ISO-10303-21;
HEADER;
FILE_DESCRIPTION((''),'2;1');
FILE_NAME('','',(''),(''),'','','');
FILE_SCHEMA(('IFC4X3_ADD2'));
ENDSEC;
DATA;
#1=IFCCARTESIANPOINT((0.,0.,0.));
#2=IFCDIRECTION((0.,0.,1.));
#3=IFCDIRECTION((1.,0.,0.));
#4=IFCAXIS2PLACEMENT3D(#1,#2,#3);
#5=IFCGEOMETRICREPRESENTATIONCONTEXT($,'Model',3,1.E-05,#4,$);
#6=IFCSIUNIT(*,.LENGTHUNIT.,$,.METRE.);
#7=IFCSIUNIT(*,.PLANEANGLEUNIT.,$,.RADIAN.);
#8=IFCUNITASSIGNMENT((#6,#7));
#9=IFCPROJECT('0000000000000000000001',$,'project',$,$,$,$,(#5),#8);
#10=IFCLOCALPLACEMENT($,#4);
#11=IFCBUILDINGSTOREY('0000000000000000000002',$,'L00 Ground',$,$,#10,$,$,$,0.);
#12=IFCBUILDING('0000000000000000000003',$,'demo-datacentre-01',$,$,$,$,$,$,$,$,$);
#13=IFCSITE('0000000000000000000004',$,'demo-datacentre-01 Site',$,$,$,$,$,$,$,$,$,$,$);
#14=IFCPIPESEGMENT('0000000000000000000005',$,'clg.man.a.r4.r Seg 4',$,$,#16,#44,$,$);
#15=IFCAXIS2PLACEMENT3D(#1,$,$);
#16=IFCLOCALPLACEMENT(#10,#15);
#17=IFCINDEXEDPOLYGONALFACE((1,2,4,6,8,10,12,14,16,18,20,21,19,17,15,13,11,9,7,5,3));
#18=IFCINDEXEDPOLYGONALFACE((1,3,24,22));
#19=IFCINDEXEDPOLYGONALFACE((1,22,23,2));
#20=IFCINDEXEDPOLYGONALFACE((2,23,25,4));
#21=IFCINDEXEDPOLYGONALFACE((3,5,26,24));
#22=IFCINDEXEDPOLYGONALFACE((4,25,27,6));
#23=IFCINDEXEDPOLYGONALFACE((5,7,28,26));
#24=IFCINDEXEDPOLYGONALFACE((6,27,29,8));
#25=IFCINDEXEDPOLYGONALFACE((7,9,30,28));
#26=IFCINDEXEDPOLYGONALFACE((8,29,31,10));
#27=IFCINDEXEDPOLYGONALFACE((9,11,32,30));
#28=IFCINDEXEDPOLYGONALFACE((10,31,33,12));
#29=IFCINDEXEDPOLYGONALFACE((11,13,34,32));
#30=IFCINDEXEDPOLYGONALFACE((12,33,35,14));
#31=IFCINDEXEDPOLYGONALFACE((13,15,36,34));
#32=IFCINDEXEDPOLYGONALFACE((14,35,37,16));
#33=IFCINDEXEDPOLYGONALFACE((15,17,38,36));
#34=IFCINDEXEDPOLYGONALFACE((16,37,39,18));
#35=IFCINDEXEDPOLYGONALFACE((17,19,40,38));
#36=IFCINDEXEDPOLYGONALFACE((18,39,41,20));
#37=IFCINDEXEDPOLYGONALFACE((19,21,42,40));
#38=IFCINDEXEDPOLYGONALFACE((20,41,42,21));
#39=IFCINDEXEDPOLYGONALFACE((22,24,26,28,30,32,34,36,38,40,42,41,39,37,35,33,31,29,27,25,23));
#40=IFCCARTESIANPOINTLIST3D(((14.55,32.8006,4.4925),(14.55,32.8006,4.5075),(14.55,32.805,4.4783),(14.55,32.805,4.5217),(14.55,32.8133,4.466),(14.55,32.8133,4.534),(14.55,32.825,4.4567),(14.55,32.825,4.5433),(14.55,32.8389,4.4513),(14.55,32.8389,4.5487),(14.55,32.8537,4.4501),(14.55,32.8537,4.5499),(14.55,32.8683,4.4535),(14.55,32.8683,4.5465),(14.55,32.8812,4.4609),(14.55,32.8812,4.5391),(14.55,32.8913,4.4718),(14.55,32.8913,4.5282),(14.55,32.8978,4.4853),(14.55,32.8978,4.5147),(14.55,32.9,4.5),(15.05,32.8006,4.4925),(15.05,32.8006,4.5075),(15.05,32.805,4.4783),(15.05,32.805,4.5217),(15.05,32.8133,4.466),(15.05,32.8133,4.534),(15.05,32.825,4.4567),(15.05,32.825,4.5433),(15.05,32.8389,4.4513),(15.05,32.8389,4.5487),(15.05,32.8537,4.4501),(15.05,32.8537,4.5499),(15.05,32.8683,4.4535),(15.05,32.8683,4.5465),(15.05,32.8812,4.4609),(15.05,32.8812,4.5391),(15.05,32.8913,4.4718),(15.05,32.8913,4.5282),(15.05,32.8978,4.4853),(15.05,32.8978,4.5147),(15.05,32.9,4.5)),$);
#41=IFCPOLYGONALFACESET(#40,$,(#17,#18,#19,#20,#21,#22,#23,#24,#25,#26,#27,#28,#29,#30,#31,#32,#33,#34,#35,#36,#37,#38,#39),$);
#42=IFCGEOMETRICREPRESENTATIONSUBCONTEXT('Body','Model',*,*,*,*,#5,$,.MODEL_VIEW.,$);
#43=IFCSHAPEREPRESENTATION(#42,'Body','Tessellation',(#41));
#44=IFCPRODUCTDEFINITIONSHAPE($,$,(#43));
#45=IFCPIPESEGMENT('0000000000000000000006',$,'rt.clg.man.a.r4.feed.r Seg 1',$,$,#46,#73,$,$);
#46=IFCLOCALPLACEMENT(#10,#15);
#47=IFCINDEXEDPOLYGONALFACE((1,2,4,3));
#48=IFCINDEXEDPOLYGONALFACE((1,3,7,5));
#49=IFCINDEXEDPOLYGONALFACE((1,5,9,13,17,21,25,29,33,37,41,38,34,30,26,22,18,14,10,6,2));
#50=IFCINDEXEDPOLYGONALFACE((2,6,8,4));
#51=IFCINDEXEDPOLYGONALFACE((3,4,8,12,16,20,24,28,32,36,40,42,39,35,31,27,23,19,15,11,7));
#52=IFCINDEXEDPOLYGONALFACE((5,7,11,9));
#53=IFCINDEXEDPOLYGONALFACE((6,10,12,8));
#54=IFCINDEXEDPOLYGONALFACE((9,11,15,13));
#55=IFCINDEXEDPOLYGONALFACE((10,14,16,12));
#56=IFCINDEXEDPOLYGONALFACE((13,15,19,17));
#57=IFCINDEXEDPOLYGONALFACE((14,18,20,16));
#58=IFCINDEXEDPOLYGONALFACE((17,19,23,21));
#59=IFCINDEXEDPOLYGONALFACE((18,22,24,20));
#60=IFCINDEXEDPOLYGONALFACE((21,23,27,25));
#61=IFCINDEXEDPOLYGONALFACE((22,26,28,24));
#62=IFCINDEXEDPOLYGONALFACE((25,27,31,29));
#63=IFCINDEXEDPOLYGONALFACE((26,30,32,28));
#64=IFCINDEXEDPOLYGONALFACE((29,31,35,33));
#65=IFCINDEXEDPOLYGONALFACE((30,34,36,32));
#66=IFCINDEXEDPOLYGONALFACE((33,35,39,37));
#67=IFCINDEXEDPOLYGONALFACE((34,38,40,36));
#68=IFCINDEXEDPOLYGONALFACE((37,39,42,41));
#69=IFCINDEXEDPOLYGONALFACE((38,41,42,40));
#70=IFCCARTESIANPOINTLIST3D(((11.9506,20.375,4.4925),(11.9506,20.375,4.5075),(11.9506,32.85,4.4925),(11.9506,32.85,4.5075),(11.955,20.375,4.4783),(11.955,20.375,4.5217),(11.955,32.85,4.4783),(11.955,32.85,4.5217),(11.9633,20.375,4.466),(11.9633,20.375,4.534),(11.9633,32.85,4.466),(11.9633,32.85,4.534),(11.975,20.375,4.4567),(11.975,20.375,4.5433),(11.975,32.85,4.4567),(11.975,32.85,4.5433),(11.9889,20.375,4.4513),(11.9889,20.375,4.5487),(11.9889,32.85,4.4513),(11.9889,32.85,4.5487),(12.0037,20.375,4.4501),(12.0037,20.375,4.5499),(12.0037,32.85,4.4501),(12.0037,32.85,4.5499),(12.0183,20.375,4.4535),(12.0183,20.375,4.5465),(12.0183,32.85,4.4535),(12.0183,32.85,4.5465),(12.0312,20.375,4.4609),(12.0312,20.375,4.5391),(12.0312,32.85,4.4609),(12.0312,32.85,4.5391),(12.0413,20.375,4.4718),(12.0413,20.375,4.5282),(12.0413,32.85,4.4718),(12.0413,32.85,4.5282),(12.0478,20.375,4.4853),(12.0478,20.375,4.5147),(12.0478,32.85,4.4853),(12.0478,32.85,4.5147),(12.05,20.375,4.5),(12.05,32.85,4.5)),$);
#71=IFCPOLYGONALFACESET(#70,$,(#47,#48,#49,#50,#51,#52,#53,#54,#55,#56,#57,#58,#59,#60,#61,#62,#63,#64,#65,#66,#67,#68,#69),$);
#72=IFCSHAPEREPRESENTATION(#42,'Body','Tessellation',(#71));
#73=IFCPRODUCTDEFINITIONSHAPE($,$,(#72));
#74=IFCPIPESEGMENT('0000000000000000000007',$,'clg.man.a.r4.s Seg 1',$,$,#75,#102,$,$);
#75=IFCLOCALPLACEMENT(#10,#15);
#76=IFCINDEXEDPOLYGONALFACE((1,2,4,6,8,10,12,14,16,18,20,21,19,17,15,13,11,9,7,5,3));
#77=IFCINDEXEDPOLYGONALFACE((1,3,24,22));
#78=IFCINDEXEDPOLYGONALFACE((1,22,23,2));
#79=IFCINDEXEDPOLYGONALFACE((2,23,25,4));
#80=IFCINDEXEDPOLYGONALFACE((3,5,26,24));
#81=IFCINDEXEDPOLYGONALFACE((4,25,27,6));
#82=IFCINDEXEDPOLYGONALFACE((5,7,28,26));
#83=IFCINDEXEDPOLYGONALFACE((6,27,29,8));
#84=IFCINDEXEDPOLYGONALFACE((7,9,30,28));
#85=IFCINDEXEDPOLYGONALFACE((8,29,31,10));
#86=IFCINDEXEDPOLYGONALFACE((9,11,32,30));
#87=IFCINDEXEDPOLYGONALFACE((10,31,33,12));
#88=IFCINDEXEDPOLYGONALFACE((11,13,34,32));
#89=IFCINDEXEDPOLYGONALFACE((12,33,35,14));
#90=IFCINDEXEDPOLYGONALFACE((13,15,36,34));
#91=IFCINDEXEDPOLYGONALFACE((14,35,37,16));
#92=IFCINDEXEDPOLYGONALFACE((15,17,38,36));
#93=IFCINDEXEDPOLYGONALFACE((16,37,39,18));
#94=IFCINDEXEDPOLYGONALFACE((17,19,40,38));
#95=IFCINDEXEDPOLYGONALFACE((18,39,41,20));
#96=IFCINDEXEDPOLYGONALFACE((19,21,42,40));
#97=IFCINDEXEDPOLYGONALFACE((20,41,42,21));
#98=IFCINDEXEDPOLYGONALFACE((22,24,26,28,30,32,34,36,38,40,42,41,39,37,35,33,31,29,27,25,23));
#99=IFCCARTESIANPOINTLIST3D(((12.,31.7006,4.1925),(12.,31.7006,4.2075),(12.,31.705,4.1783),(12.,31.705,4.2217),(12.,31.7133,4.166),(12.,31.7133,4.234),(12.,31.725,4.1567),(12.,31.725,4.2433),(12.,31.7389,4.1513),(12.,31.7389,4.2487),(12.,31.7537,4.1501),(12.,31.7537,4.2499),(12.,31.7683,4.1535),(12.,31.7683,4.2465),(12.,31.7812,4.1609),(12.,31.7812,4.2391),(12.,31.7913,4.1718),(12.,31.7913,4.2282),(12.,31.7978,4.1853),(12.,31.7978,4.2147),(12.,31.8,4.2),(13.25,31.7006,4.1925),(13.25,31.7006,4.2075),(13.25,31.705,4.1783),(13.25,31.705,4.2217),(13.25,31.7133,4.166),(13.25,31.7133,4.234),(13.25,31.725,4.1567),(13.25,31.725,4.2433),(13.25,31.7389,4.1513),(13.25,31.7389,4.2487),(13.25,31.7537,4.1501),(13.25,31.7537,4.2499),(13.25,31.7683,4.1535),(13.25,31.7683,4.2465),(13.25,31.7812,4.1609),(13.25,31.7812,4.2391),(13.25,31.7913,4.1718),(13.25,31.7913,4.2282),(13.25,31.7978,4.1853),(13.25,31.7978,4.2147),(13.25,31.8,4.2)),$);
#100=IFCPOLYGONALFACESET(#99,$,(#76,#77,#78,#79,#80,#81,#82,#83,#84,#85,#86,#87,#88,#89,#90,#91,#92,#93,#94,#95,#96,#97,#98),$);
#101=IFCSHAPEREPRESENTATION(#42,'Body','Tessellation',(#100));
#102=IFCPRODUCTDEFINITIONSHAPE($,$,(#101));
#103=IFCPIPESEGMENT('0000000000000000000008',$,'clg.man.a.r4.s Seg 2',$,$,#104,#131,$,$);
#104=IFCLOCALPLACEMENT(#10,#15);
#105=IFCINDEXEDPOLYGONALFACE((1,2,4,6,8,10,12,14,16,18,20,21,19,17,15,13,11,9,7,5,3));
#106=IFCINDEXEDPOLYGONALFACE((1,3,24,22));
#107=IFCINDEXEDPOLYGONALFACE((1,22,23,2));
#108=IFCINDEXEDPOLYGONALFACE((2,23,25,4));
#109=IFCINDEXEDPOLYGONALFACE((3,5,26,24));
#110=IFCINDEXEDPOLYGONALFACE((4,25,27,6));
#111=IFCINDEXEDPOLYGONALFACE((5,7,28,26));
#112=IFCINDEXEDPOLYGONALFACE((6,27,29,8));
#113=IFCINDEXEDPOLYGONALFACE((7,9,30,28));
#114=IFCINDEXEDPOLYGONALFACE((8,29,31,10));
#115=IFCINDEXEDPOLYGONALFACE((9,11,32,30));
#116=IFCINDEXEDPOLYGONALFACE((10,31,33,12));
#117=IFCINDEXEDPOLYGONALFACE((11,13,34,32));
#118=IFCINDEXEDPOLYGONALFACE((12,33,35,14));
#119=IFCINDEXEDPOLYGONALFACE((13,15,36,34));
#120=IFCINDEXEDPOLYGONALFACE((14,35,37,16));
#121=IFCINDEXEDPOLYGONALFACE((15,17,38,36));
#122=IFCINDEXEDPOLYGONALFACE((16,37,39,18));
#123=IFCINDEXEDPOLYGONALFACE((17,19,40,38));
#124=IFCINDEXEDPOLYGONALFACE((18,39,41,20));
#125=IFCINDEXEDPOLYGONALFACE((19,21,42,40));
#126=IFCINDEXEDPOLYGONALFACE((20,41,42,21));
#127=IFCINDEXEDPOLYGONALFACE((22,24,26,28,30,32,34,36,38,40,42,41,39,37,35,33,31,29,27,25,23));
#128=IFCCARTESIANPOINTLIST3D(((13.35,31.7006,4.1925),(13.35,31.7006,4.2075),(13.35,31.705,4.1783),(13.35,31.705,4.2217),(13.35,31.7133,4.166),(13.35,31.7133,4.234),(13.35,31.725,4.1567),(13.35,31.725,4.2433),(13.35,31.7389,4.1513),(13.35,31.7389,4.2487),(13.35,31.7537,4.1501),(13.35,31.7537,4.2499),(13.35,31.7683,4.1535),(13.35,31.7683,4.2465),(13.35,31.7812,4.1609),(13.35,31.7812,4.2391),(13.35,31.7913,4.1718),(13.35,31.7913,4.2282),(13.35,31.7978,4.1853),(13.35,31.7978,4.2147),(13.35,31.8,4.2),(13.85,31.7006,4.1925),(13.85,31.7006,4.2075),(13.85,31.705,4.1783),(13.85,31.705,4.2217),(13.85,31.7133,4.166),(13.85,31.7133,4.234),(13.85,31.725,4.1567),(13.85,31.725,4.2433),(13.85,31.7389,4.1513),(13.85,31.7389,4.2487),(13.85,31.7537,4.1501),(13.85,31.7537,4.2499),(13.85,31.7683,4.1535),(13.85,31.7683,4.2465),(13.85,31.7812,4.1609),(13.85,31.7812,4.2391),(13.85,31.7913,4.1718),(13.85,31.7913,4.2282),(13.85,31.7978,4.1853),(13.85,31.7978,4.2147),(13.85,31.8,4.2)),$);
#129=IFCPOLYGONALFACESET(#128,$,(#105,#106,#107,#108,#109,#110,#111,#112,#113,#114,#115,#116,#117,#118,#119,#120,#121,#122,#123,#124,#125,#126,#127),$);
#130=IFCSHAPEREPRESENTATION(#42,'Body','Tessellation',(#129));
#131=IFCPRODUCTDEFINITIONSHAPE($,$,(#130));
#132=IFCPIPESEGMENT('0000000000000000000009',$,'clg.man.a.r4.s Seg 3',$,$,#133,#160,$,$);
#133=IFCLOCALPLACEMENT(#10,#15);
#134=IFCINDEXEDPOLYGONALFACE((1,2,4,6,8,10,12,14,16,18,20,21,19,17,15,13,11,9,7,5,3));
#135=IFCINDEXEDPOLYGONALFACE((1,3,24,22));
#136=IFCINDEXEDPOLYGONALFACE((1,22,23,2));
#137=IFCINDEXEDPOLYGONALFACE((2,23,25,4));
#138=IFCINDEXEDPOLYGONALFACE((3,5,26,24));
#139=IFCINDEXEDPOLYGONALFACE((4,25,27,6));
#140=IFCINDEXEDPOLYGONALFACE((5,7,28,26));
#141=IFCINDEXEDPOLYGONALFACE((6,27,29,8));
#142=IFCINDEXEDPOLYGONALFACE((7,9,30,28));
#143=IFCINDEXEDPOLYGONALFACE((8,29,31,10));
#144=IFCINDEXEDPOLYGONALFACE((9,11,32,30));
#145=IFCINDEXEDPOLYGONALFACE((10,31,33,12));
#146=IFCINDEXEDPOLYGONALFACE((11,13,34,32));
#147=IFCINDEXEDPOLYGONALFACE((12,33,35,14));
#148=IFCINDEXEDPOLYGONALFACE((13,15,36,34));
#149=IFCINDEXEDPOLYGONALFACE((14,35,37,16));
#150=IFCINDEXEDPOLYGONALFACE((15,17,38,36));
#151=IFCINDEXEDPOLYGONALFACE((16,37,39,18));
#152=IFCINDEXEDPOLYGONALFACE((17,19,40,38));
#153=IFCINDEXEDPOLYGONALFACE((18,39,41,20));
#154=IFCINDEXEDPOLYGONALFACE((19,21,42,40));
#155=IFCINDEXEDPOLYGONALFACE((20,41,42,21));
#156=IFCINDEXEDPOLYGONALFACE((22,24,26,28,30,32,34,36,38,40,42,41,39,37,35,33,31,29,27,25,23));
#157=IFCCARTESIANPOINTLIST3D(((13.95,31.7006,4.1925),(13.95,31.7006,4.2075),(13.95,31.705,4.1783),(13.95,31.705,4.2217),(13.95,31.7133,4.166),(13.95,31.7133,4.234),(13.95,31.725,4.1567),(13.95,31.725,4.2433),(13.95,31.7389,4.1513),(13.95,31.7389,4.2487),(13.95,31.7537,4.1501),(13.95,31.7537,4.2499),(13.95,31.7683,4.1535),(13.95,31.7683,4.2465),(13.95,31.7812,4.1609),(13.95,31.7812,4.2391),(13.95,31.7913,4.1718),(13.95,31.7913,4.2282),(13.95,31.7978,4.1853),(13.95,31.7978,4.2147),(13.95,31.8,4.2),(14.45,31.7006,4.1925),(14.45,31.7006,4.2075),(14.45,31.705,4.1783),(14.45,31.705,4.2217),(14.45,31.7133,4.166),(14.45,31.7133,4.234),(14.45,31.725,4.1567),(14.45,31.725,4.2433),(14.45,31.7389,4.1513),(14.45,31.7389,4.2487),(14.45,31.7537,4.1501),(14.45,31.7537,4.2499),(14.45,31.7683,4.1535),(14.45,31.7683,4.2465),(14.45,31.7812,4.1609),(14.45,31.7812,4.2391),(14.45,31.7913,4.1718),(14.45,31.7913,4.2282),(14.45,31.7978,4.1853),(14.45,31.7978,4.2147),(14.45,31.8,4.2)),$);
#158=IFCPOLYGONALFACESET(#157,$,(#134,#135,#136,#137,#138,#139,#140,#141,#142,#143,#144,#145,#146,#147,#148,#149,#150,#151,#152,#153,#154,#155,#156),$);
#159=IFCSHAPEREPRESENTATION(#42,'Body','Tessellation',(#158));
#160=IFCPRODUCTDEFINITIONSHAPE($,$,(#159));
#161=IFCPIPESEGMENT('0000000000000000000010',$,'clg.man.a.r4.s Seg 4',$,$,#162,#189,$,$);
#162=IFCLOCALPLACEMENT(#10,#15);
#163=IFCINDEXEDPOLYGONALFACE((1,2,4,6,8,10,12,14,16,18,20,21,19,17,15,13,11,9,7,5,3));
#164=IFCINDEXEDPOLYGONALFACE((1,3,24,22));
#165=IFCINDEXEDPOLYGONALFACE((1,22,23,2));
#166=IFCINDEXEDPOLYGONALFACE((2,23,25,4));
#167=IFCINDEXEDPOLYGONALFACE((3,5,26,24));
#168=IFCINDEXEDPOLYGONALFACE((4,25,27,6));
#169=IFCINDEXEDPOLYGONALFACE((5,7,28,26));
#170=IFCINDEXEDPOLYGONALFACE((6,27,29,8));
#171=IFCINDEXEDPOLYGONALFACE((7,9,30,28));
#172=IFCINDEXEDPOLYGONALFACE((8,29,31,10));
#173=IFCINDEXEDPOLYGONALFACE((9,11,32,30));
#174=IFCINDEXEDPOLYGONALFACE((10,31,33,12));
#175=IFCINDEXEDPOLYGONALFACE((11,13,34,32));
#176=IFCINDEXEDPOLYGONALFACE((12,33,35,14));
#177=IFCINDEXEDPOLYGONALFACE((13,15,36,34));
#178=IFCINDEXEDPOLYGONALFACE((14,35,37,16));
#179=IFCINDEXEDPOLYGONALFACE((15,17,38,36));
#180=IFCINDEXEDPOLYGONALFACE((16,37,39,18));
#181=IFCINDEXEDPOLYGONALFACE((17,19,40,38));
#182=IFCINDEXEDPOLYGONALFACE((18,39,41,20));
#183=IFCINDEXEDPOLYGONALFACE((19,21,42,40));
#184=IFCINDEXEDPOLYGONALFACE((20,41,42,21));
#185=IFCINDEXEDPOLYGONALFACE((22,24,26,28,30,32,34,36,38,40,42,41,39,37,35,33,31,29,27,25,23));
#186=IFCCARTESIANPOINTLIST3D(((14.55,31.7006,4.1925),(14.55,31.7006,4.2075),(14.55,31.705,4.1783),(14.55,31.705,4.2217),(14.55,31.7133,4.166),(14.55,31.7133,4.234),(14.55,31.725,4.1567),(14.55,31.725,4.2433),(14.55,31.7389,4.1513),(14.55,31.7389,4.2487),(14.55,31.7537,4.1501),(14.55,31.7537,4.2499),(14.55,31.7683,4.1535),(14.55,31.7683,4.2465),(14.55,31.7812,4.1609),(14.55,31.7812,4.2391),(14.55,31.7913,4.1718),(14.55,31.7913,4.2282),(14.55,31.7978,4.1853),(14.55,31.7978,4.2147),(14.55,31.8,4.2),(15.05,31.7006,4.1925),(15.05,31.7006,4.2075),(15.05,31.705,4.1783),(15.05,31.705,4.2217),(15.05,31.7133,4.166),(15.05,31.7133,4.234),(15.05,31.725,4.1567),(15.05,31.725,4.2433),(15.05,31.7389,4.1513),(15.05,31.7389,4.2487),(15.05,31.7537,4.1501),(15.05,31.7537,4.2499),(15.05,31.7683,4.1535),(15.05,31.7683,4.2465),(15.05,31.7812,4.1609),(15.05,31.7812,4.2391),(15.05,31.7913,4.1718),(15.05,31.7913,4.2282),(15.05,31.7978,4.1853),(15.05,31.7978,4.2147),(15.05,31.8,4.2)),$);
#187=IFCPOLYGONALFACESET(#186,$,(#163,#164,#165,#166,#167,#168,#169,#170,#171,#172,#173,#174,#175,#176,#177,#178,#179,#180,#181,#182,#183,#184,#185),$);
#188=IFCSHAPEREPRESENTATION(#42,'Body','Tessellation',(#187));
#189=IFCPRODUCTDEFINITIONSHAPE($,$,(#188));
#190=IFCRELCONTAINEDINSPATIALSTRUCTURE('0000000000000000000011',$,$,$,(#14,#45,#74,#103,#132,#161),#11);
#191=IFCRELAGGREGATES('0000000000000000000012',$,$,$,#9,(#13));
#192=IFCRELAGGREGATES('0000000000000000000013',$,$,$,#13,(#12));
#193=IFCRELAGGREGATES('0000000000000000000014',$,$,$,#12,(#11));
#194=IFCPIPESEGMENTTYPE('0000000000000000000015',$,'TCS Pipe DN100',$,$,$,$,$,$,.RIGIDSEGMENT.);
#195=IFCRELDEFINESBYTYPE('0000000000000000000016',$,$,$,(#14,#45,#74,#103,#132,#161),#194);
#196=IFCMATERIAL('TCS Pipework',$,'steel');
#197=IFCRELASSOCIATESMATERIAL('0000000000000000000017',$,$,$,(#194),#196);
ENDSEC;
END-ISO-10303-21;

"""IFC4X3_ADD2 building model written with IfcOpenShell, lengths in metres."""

from ifc_helpers import new_model, si_unit, frame, origin_with_axes, place, context, subcontext, project, spatial, circle, extrude, material, type_object, element, save


model = new_model("IFC4X3_ADD2")

# Units and contexts
model_context = context("Model", 3, precision=1e-05, world=origin_with_axes())
body_context = subcontext(model_context, "Body", "Model", "MODEL_VIEW")
ifc_project = project(units=[si_unit("LENGTHUNIT", "METRE"), si_unit("PLANEANGLEUNIT", "RADIAN")], contexts=[model_context])

# Site, building, storey
site = spatial("IfcSite", under=ifc_project, Name="demo-datacentre-01 Site")
building = spatial("IfcBuilding", under=site, Name="demo-datacentre-01")
storey_placement = place(None, origin_with_axes())
storey = spatial("IfcBuildingStorey", under=building, at=storey_placement, Name="L00 Ground", Elevation=0.0)

# Shared definitions
ifc_material = material(Name="TCS Pipework", Category="steel")

# Pipe segments
pipe_segment_type_1 = type_object("IfcPipeSegmentType", Name="TCS Pipe DN100", PredefinedType="RIGIDSEGMENT", material=ifc_material)
pipe_segment_1_placement = place(storey_placement, frame((14.55, 32.85, 4.5), z_axis=(1.0, 0.0, 0.0), x_axis=(0.0, 1.0, 0.0)))
element("IfcPipeSegment", 1, at=pipe_segment_1_placement, inside=storey, type_object=pipe_segment_type_1, Name="clg.man.a.r4.r Seg 4", context=body_context, shape_type="SweptSolid", body=[
    extrude(circle(Radius=0.05), origin_with_axes(), (0.0, 0.0, 1.0), 0.5),
])
pipe_segment_2_placement = place(storey_placement, frame((12.0, 32.85, 4.5), z_axis=(0.0, -1.0, 0.0), x_axis=(1.0, 0.0, 0.0)))
element("IfcPipeSegment", 2, at=pipe_segment_2_placement, inside=storey, type_object=pipe_segment_type_1, Name="rt.clg.man.a.r4.feed.r Seg 1", context=body_context, shape_type="SweptSolid", body=[
    extrude(circle(Radius=0.05), origin_with_axes(), (0.0, 0.0, 1.0), 12.475),
])
pipe_segment_3_placement = place(storey_placement, frame((12.0, 31.75, 4.2), z_axis=(1.0, 0.0, 0.0), x_axis=(0.0, 1.0, 0.0)))
element("IfcPipeSegment", 3, at=pipe_segment_3_placement, inside=storey, type_object=pipe_segment_type_1, Name="clg.man.a.r4.s Seg 1", context=body_context, shape_type="SweptSolid", body=[
    extrude(circle(Radius=0.05), origin_with_axes(), (0.0, 0.0, 1.0), 1.25),
])
for number, where, z_axis, x_axis, name in (
    (4, (13.35, 31.75, 4.2), (1.0, 0.0, 0.0), (0.0, 1.0, 0.0), "clg.man.a.r4.s Seg 2"),
    (5, (13.95, 31.75, 4.2), (1.0, 0.0, 0.0), (0.0, 1.0, 0.0), "clg.man.a.r4.s Seg 3"),
):
    element("IfcPipeSegment", number, at=place(storey_placement, frame(where, z_axis=z_axis, x_axis=x_axis)), inside=storey, type_object=pipe_segment_type_1, Name=name, context=body_context, shape_type="SweptSolid", body=[
        extrude(circle(Radius=0.05), origin_with_axes(), (0.0, 0.0, 1.0), 0.5),
    ])
pipe_segment_4_placement = place(storey_placement, frame((14.55, 31.75, 4.2), z_axis=(1.0, 0.0, 0.0), x_axis=(0.0, 1.0, 0.0)))
element("IfcPipeSegment", 6, at=pipe_segment_4_placement, inside=storey, type_object=pipe_segment_type_1, Name="clg.man.a.r4.s Seg 4", context=body_context, shape_type="SweptSolid", body=[
    extrude(circle(Radius=0.05), origin_with_axes(), (0.0, 0.0, 1.0), 0.5),
])

save(model, "model.ifc")
